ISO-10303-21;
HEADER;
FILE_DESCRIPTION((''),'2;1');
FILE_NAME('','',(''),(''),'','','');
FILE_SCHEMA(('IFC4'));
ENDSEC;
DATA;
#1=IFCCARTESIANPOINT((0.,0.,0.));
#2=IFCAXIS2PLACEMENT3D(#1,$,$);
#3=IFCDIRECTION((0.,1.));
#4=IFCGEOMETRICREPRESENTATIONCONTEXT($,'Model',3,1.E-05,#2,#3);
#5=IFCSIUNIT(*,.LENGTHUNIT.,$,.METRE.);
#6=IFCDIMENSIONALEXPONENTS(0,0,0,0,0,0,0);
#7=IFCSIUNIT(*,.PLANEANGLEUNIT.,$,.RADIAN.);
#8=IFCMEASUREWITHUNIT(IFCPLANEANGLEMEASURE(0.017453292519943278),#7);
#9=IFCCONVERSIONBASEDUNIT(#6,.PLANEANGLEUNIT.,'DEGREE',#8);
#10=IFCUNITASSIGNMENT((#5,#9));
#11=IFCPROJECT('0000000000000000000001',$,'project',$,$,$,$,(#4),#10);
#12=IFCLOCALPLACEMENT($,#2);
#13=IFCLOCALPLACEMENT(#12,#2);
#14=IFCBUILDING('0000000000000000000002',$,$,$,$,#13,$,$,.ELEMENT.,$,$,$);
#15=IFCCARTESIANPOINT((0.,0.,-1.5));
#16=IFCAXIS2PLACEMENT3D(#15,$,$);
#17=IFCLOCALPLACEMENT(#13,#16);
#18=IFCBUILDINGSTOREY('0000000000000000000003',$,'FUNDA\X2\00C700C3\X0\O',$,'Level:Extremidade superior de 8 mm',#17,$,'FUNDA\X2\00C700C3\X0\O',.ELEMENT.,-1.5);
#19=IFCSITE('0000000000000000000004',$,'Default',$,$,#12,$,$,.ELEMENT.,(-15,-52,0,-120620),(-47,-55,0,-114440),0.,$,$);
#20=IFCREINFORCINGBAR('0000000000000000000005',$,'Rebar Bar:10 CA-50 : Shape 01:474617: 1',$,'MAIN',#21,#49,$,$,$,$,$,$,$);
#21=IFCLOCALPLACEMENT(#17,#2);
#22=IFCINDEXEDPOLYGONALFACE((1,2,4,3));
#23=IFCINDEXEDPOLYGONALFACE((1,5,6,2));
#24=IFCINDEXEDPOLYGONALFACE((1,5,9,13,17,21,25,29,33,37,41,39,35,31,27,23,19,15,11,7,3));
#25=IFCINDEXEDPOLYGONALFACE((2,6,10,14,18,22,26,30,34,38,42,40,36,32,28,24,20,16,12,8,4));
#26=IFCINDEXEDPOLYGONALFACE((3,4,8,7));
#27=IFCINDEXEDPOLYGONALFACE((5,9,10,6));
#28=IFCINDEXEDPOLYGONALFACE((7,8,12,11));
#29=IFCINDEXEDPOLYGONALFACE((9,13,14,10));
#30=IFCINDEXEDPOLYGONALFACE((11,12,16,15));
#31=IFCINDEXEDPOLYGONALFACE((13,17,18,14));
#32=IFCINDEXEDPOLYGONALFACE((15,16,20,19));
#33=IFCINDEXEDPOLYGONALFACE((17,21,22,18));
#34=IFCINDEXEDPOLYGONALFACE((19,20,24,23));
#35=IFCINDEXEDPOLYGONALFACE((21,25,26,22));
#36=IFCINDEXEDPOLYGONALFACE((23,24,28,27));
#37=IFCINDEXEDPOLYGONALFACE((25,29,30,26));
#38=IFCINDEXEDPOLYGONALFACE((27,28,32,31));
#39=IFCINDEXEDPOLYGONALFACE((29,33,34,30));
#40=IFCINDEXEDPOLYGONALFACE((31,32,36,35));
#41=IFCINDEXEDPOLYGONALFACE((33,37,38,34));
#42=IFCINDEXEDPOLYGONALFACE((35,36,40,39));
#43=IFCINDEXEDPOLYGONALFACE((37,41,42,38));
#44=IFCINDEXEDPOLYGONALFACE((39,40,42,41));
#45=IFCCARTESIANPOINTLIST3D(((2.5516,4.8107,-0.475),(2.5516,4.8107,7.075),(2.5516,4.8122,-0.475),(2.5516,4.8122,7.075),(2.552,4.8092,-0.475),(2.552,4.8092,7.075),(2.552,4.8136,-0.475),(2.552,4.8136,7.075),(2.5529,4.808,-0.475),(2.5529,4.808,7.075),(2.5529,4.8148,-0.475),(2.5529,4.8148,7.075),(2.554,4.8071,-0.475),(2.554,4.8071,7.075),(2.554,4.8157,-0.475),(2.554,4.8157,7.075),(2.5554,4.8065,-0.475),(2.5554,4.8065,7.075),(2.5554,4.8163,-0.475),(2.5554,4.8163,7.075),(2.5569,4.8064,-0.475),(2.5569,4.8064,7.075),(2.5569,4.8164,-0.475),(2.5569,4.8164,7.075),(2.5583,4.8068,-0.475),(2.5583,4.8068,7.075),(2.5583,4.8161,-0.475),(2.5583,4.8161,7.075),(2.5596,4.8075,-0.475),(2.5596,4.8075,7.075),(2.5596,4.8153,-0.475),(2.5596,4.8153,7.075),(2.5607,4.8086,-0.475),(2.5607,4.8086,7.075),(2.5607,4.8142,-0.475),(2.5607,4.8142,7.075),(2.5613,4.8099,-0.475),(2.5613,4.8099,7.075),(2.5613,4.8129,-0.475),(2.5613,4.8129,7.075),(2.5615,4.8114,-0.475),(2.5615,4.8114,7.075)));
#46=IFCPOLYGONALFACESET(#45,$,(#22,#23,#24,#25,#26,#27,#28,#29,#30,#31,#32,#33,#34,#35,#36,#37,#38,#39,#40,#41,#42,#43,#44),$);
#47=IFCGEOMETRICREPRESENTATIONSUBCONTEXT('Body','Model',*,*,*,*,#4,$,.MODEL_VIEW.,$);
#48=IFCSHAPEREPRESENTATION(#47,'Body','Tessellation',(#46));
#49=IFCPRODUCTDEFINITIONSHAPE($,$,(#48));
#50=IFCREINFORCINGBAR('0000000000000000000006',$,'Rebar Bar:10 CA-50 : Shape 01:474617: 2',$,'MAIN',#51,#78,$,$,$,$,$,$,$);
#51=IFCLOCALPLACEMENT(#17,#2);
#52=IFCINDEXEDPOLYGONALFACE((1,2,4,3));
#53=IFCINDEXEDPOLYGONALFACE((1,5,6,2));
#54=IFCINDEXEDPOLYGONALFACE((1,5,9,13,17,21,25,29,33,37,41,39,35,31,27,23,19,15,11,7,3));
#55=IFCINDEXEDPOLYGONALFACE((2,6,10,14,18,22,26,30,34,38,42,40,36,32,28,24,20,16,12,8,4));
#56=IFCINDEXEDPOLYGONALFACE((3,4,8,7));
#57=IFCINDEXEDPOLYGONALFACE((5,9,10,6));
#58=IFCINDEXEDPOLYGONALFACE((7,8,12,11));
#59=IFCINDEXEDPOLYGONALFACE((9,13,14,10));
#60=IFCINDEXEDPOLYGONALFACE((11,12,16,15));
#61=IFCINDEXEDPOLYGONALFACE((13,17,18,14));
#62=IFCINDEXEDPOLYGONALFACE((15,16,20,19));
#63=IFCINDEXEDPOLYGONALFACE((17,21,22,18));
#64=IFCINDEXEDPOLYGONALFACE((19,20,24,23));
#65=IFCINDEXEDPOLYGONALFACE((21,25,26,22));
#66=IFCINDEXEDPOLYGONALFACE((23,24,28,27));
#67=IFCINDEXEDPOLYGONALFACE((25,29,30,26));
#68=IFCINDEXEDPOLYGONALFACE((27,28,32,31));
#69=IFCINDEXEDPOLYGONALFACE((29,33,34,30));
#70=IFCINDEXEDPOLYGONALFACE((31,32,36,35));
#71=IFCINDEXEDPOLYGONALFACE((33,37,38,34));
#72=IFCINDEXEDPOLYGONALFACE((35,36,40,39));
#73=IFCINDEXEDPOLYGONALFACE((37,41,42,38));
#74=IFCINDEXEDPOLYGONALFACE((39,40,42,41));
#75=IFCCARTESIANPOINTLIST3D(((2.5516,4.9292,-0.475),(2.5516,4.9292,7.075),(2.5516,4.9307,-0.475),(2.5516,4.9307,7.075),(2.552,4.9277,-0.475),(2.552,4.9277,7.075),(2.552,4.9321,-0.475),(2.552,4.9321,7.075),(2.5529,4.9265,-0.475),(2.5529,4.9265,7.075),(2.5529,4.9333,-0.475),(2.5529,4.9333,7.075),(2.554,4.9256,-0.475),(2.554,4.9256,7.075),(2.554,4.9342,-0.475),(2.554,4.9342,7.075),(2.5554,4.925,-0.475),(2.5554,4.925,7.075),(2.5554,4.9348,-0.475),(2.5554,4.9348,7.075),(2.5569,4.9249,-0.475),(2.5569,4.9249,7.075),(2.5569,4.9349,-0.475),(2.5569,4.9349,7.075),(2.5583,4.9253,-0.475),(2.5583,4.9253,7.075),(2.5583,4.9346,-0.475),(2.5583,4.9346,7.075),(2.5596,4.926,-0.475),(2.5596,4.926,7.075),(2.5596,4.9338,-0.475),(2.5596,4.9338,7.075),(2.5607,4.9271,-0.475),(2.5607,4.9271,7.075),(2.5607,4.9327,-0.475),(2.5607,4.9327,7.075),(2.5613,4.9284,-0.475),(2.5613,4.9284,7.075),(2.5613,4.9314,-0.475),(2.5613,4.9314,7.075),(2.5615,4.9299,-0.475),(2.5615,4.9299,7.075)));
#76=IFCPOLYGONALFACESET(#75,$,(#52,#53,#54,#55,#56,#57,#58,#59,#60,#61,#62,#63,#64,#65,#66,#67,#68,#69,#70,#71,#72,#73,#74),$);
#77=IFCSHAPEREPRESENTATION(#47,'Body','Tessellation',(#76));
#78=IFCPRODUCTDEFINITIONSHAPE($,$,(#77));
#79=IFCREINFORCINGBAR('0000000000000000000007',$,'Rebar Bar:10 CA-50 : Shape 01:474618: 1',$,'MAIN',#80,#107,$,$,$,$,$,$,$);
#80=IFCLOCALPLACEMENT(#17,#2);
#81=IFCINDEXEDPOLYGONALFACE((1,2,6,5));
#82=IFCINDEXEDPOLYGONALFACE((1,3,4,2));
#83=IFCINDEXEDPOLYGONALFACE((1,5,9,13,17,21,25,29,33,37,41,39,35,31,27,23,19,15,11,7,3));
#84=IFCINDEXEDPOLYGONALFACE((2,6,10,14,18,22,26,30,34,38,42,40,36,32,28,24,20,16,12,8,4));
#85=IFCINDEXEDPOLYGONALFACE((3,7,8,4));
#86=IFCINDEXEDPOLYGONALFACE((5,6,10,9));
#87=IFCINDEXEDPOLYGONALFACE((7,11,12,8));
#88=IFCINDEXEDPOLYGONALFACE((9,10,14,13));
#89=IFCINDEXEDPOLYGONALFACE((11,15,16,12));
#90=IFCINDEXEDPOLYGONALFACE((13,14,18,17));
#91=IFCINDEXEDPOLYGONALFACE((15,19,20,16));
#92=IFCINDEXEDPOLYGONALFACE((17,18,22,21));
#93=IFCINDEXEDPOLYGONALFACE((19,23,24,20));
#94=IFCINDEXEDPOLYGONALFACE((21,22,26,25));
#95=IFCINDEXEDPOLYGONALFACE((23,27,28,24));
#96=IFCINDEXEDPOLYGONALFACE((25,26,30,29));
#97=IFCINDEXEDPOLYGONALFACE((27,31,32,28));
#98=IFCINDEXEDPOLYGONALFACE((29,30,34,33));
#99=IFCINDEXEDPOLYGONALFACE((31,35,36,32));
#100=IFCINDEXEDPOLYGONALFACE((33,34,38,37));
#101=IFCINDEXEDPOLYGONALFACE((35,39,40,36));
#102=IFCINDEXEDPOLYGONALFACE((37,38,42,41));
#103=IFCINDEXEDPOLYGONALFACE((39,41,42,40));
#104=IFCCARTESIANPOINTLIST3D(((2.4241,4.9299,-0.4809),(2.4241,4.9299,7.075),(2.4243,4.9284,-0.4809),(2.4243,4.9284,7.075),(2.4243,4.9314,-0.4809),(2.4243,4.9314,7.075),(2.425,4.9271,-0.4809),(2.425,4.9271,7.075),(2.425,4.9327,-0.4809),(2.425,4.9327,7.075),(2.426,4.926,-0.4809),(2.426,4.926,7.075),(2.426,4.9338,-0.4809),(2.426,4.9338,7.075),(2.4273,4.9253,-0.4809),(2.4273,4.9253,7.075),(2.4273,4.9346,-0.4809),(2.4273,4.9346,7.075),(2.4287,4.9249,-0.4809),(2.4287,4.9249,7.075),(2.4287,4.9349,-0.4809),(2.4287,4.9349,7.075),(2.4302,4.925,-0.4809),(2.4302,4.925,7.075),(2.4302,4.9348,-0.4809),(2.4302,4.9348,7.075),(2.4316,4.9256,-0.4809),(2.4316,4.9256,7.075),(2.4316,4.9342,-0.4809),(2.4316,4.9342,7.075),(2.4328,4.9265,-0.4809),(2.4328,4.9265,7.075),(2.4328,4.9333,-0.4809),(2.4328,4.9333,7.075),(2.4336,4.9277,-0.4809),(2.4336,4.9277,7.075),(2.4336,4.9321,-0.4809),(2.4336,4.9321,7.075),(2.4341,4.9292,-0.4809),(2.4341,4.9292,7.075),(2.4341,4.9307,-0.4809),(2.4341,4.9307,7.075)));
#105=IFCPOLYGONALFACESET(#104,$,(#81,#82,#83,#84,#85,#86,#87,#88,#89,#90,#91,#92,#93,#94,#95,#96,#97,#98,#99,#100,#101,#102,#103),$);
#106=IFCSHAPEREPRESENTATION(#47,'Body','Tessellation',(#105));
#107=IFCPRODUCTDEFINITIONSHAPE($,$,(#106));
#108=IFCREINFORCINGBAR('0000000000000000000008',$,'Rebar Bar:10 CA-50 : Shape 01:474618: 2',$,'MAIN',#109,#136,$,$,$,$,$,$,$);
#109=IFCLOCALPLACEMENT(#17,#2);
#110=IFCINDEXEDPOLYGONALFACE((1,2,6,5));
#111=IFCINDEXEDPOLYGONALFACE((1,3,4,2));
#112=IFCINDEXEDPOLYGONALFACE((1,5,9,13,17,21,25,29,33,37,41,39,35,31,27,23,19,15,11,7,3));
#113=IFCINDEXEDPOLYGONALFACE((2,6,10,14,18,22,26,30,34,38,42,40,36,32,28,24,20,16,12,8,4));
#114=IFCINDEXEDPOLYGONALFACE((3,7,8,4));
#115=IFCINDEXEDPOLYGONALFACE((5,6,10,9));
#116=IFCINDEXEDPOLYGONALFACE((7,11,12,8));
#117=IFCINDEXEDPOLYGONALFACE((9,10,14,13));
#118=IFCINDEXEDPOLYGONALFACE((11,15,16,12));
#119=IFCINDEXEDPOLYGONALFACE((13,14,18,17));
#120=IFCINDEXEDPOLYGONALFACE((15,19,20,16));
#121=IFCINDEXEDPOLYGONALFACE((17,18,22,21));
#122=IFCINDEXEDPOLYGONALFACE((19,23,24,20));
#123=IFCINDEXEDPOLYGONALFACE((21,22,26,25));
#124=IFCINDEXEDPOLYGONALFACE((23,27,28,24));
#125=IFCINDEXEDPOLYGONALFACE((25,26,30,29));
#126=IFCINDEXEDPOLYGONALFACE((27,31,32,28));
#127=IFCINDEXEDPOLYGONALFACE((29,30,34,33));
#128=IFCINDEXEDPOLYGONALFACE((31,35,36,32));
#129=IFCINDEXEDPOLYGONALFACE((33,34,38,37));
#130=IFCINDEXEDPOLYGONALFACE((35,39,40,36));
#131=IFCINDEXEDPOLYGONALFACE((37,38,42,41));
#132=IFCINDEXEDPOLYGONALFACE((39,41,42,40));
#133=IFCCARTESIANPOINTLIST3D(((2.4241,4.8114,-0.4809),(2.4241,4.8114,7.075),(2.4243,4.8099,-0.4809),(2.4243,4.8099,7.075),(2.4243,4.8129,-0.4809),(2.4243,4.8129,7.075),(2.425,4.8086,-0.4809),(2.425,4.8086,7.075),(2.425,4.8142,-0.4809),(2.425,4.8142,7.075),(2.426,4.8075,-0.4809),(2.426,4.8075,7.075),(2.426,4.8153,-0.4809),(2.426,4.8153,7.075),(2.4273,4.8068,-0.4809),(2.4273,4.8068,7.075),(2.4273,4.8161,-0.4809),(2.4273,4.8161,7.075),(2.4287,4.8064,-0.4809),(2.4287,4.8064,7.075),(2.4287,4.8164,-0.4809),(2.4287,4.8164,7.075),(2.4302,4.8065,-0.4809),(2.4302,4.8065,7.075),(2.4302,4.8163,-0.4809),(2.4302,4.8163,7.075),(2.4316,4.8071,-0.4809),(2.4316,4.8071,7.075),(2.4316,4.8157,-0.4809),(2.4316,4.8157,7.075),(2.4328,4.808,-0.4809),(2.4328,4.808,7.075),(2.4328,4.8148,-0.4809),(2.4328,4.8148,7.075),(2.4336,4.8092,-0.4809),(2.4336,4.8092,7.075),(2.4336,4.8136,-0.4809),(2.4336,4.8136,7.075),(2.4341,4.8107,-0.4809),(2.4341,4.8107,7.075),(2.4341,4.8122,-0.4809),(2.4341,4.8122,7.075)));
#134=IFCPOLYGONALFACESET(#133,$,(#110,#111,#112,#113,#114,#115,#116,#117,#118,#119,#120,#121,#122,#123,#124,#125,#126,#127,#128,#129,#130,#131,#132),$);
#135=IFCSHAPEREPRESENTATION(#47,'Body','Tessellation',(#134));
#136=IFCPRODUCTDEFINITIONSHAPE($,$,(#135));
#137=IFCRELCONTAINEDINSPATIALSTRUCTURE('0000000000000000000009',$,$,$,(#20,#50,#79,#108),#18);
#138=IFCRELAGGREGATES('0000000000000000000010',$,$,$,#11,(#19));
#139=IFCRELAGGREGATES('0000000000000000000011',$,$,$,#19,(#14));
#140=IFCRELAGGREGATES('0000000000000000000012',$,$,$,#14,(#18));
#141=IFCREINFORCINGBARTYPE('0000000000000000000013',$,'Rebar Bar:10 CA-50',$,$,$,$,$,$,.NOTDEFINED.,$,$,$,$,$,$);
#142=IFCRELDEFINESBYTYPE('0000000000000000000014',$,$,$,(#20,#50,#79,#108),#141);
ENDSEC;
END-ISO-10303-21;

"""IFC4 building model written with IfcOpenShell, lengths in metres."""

from ifc_helpers import new_model, entity, si_unit, converted_unit, direction, frame, origin, place, context, subcontext, project, spatial, type_object, element, save


model = new_model("IFC4")

# Units and contexts
model_context = context("Model", 3, precision=1e-05, world=origin(), true_north=direction((0.0, 1.0)))
body_context = subcontext(model_context, "Body", "Model", "MODEL_VIEW")
ifc_project = project(units=[si_unit("LENGTHUNIT", "METRE"), converted_unit("PLANEANGLEUNIT", "DEGREE", entity("IfcPlaneAngleMeasure", 0.017453292519943278), si_unit("PLANEANGLEUNIT", "RADIAN"), dimensions=[0, 0, 0, 0, 0, 0, 0])], contexts=[model_context])

# Site, building, storey
site_placement = place(None, origin())
site = spatial("IfcSite", under=ifc_project, at=site_placement, Name="Default", CompositionType="ELEMENT", RefLatitude=(-15, -52, 0, -120620), RefLongitude=(-47, -55, 0, -114440), RefElevation=0.0)
building_placement = place(site_placement, origin())
building = spatial("IfcBuilding", under=site, at=building_placement, CompositionType="ELEMENT")
storey_placement = place(building_placement, frame((0.0, 0.0, -1.5)))
storey = spatial("IfcBuildingStorey", under=building, at=storey_placement, Name="FUNDAÇÃO", ObjectType="Level:Extremidade superior de 8 mm", LongName="FUNDAÇÃO", CompositionType="ELEMENT", Elevation=-1.5)

# Reinforcing bars
reinforcing_bar_type_1 = type_object("IfcReinforcingBarType", Name="Rebar Bar:10 CA-50", PredefinedType="NOTDEFINED")
reinforcing_bar_1_placement = place(storey_placement, origin())
element("IfcReinforcingBar", 1, at=reinforcing_bar_1_placement, inside=storey, type_object=reinforcing_bar_type_1, Name="Rebar Bar:10 CA-50 : Shape 01:474617: 1", ObjectType="MAIN", context=body_context, shape_type="AdvancedSweptSolid", body=[
    entity("IfcSweptDiskSolid", entity("IfcIndexedPolyCurve", entity("IfcCartesianPointList3D", [[2.5565, 4.8114, -0.475], [2.5565, 4.8114, 7.075]]), None, False), 0.005, None, 0.0, 1.0),
])
reinforcing_bar_2_placement = place(storey_placement, origin())
element("IfcReinforcingBar", 2, at=reinforcing_bar_2_placement, inside=storey, type_object=reinforcing_bar_type_1, Name="Rebar Bar:10 CA-50 : Shape 01:474617: 2", ObjectType="MAIN", context=body_context, shape_type="AdvancedSweptSolid", body=[
    entity("IfcSweptDiskSolid", entity("IfcIndexedPolyCurve", entity("IfcCartesianPointList3D", [[2.5565, 4.9299, -0.475], [2.5565, 4.9299, 7.075]]), None, False), 0.005, None, 0.0, 1.0),
])
reinforcing_bar_3_placement = place(storey_placement, origin())
element("IfcReinforcingBar", 3, at=reinforcing_bar_3_placement, inside=storey, type_object=reinforcing_bar_type_1, Name="Rebar Bar:10 CA-50 : Shape 01:474618: 1", ObjectType="MAIN", context=body_context, shape_type="AdvancedSweptSolid", body=[
    entity("IfcSweptDiskSolid", entity("IfcIndexedPolyCurve", entity("IfcCartesianPointList3D", [[2.4291, 4.9299, 7.075], [2.4291, 4.9299, -0.4809]]), None, False), 0.005, None, 0.0, 1.0),
])
reinforcing_bar_4_placement = place(storey_placement, origin())
element("IfcReinforcingBar", 4, at=reinforcing_bar_4_placement, inside=storey, type_object=reinforcing_bar_type_1, Name="Rebar Bar:10 CA-50 : Shape 01:474618: 2", ObjectType="MAIN", context=body_context, shape_type="AdvancedSweptSolid", body=[
    entity("IfcSweptDiskSolid", entity("IfcIndexedPolyCurve", entity("IfcCartesianPointList3D", [[2.4291, 4.8114, 7.075], [2.4291, 4.8114, -0.4809]]), None, False), 0.005, None, 0.0, 1.0),
])

save(model, "model.ifc")
